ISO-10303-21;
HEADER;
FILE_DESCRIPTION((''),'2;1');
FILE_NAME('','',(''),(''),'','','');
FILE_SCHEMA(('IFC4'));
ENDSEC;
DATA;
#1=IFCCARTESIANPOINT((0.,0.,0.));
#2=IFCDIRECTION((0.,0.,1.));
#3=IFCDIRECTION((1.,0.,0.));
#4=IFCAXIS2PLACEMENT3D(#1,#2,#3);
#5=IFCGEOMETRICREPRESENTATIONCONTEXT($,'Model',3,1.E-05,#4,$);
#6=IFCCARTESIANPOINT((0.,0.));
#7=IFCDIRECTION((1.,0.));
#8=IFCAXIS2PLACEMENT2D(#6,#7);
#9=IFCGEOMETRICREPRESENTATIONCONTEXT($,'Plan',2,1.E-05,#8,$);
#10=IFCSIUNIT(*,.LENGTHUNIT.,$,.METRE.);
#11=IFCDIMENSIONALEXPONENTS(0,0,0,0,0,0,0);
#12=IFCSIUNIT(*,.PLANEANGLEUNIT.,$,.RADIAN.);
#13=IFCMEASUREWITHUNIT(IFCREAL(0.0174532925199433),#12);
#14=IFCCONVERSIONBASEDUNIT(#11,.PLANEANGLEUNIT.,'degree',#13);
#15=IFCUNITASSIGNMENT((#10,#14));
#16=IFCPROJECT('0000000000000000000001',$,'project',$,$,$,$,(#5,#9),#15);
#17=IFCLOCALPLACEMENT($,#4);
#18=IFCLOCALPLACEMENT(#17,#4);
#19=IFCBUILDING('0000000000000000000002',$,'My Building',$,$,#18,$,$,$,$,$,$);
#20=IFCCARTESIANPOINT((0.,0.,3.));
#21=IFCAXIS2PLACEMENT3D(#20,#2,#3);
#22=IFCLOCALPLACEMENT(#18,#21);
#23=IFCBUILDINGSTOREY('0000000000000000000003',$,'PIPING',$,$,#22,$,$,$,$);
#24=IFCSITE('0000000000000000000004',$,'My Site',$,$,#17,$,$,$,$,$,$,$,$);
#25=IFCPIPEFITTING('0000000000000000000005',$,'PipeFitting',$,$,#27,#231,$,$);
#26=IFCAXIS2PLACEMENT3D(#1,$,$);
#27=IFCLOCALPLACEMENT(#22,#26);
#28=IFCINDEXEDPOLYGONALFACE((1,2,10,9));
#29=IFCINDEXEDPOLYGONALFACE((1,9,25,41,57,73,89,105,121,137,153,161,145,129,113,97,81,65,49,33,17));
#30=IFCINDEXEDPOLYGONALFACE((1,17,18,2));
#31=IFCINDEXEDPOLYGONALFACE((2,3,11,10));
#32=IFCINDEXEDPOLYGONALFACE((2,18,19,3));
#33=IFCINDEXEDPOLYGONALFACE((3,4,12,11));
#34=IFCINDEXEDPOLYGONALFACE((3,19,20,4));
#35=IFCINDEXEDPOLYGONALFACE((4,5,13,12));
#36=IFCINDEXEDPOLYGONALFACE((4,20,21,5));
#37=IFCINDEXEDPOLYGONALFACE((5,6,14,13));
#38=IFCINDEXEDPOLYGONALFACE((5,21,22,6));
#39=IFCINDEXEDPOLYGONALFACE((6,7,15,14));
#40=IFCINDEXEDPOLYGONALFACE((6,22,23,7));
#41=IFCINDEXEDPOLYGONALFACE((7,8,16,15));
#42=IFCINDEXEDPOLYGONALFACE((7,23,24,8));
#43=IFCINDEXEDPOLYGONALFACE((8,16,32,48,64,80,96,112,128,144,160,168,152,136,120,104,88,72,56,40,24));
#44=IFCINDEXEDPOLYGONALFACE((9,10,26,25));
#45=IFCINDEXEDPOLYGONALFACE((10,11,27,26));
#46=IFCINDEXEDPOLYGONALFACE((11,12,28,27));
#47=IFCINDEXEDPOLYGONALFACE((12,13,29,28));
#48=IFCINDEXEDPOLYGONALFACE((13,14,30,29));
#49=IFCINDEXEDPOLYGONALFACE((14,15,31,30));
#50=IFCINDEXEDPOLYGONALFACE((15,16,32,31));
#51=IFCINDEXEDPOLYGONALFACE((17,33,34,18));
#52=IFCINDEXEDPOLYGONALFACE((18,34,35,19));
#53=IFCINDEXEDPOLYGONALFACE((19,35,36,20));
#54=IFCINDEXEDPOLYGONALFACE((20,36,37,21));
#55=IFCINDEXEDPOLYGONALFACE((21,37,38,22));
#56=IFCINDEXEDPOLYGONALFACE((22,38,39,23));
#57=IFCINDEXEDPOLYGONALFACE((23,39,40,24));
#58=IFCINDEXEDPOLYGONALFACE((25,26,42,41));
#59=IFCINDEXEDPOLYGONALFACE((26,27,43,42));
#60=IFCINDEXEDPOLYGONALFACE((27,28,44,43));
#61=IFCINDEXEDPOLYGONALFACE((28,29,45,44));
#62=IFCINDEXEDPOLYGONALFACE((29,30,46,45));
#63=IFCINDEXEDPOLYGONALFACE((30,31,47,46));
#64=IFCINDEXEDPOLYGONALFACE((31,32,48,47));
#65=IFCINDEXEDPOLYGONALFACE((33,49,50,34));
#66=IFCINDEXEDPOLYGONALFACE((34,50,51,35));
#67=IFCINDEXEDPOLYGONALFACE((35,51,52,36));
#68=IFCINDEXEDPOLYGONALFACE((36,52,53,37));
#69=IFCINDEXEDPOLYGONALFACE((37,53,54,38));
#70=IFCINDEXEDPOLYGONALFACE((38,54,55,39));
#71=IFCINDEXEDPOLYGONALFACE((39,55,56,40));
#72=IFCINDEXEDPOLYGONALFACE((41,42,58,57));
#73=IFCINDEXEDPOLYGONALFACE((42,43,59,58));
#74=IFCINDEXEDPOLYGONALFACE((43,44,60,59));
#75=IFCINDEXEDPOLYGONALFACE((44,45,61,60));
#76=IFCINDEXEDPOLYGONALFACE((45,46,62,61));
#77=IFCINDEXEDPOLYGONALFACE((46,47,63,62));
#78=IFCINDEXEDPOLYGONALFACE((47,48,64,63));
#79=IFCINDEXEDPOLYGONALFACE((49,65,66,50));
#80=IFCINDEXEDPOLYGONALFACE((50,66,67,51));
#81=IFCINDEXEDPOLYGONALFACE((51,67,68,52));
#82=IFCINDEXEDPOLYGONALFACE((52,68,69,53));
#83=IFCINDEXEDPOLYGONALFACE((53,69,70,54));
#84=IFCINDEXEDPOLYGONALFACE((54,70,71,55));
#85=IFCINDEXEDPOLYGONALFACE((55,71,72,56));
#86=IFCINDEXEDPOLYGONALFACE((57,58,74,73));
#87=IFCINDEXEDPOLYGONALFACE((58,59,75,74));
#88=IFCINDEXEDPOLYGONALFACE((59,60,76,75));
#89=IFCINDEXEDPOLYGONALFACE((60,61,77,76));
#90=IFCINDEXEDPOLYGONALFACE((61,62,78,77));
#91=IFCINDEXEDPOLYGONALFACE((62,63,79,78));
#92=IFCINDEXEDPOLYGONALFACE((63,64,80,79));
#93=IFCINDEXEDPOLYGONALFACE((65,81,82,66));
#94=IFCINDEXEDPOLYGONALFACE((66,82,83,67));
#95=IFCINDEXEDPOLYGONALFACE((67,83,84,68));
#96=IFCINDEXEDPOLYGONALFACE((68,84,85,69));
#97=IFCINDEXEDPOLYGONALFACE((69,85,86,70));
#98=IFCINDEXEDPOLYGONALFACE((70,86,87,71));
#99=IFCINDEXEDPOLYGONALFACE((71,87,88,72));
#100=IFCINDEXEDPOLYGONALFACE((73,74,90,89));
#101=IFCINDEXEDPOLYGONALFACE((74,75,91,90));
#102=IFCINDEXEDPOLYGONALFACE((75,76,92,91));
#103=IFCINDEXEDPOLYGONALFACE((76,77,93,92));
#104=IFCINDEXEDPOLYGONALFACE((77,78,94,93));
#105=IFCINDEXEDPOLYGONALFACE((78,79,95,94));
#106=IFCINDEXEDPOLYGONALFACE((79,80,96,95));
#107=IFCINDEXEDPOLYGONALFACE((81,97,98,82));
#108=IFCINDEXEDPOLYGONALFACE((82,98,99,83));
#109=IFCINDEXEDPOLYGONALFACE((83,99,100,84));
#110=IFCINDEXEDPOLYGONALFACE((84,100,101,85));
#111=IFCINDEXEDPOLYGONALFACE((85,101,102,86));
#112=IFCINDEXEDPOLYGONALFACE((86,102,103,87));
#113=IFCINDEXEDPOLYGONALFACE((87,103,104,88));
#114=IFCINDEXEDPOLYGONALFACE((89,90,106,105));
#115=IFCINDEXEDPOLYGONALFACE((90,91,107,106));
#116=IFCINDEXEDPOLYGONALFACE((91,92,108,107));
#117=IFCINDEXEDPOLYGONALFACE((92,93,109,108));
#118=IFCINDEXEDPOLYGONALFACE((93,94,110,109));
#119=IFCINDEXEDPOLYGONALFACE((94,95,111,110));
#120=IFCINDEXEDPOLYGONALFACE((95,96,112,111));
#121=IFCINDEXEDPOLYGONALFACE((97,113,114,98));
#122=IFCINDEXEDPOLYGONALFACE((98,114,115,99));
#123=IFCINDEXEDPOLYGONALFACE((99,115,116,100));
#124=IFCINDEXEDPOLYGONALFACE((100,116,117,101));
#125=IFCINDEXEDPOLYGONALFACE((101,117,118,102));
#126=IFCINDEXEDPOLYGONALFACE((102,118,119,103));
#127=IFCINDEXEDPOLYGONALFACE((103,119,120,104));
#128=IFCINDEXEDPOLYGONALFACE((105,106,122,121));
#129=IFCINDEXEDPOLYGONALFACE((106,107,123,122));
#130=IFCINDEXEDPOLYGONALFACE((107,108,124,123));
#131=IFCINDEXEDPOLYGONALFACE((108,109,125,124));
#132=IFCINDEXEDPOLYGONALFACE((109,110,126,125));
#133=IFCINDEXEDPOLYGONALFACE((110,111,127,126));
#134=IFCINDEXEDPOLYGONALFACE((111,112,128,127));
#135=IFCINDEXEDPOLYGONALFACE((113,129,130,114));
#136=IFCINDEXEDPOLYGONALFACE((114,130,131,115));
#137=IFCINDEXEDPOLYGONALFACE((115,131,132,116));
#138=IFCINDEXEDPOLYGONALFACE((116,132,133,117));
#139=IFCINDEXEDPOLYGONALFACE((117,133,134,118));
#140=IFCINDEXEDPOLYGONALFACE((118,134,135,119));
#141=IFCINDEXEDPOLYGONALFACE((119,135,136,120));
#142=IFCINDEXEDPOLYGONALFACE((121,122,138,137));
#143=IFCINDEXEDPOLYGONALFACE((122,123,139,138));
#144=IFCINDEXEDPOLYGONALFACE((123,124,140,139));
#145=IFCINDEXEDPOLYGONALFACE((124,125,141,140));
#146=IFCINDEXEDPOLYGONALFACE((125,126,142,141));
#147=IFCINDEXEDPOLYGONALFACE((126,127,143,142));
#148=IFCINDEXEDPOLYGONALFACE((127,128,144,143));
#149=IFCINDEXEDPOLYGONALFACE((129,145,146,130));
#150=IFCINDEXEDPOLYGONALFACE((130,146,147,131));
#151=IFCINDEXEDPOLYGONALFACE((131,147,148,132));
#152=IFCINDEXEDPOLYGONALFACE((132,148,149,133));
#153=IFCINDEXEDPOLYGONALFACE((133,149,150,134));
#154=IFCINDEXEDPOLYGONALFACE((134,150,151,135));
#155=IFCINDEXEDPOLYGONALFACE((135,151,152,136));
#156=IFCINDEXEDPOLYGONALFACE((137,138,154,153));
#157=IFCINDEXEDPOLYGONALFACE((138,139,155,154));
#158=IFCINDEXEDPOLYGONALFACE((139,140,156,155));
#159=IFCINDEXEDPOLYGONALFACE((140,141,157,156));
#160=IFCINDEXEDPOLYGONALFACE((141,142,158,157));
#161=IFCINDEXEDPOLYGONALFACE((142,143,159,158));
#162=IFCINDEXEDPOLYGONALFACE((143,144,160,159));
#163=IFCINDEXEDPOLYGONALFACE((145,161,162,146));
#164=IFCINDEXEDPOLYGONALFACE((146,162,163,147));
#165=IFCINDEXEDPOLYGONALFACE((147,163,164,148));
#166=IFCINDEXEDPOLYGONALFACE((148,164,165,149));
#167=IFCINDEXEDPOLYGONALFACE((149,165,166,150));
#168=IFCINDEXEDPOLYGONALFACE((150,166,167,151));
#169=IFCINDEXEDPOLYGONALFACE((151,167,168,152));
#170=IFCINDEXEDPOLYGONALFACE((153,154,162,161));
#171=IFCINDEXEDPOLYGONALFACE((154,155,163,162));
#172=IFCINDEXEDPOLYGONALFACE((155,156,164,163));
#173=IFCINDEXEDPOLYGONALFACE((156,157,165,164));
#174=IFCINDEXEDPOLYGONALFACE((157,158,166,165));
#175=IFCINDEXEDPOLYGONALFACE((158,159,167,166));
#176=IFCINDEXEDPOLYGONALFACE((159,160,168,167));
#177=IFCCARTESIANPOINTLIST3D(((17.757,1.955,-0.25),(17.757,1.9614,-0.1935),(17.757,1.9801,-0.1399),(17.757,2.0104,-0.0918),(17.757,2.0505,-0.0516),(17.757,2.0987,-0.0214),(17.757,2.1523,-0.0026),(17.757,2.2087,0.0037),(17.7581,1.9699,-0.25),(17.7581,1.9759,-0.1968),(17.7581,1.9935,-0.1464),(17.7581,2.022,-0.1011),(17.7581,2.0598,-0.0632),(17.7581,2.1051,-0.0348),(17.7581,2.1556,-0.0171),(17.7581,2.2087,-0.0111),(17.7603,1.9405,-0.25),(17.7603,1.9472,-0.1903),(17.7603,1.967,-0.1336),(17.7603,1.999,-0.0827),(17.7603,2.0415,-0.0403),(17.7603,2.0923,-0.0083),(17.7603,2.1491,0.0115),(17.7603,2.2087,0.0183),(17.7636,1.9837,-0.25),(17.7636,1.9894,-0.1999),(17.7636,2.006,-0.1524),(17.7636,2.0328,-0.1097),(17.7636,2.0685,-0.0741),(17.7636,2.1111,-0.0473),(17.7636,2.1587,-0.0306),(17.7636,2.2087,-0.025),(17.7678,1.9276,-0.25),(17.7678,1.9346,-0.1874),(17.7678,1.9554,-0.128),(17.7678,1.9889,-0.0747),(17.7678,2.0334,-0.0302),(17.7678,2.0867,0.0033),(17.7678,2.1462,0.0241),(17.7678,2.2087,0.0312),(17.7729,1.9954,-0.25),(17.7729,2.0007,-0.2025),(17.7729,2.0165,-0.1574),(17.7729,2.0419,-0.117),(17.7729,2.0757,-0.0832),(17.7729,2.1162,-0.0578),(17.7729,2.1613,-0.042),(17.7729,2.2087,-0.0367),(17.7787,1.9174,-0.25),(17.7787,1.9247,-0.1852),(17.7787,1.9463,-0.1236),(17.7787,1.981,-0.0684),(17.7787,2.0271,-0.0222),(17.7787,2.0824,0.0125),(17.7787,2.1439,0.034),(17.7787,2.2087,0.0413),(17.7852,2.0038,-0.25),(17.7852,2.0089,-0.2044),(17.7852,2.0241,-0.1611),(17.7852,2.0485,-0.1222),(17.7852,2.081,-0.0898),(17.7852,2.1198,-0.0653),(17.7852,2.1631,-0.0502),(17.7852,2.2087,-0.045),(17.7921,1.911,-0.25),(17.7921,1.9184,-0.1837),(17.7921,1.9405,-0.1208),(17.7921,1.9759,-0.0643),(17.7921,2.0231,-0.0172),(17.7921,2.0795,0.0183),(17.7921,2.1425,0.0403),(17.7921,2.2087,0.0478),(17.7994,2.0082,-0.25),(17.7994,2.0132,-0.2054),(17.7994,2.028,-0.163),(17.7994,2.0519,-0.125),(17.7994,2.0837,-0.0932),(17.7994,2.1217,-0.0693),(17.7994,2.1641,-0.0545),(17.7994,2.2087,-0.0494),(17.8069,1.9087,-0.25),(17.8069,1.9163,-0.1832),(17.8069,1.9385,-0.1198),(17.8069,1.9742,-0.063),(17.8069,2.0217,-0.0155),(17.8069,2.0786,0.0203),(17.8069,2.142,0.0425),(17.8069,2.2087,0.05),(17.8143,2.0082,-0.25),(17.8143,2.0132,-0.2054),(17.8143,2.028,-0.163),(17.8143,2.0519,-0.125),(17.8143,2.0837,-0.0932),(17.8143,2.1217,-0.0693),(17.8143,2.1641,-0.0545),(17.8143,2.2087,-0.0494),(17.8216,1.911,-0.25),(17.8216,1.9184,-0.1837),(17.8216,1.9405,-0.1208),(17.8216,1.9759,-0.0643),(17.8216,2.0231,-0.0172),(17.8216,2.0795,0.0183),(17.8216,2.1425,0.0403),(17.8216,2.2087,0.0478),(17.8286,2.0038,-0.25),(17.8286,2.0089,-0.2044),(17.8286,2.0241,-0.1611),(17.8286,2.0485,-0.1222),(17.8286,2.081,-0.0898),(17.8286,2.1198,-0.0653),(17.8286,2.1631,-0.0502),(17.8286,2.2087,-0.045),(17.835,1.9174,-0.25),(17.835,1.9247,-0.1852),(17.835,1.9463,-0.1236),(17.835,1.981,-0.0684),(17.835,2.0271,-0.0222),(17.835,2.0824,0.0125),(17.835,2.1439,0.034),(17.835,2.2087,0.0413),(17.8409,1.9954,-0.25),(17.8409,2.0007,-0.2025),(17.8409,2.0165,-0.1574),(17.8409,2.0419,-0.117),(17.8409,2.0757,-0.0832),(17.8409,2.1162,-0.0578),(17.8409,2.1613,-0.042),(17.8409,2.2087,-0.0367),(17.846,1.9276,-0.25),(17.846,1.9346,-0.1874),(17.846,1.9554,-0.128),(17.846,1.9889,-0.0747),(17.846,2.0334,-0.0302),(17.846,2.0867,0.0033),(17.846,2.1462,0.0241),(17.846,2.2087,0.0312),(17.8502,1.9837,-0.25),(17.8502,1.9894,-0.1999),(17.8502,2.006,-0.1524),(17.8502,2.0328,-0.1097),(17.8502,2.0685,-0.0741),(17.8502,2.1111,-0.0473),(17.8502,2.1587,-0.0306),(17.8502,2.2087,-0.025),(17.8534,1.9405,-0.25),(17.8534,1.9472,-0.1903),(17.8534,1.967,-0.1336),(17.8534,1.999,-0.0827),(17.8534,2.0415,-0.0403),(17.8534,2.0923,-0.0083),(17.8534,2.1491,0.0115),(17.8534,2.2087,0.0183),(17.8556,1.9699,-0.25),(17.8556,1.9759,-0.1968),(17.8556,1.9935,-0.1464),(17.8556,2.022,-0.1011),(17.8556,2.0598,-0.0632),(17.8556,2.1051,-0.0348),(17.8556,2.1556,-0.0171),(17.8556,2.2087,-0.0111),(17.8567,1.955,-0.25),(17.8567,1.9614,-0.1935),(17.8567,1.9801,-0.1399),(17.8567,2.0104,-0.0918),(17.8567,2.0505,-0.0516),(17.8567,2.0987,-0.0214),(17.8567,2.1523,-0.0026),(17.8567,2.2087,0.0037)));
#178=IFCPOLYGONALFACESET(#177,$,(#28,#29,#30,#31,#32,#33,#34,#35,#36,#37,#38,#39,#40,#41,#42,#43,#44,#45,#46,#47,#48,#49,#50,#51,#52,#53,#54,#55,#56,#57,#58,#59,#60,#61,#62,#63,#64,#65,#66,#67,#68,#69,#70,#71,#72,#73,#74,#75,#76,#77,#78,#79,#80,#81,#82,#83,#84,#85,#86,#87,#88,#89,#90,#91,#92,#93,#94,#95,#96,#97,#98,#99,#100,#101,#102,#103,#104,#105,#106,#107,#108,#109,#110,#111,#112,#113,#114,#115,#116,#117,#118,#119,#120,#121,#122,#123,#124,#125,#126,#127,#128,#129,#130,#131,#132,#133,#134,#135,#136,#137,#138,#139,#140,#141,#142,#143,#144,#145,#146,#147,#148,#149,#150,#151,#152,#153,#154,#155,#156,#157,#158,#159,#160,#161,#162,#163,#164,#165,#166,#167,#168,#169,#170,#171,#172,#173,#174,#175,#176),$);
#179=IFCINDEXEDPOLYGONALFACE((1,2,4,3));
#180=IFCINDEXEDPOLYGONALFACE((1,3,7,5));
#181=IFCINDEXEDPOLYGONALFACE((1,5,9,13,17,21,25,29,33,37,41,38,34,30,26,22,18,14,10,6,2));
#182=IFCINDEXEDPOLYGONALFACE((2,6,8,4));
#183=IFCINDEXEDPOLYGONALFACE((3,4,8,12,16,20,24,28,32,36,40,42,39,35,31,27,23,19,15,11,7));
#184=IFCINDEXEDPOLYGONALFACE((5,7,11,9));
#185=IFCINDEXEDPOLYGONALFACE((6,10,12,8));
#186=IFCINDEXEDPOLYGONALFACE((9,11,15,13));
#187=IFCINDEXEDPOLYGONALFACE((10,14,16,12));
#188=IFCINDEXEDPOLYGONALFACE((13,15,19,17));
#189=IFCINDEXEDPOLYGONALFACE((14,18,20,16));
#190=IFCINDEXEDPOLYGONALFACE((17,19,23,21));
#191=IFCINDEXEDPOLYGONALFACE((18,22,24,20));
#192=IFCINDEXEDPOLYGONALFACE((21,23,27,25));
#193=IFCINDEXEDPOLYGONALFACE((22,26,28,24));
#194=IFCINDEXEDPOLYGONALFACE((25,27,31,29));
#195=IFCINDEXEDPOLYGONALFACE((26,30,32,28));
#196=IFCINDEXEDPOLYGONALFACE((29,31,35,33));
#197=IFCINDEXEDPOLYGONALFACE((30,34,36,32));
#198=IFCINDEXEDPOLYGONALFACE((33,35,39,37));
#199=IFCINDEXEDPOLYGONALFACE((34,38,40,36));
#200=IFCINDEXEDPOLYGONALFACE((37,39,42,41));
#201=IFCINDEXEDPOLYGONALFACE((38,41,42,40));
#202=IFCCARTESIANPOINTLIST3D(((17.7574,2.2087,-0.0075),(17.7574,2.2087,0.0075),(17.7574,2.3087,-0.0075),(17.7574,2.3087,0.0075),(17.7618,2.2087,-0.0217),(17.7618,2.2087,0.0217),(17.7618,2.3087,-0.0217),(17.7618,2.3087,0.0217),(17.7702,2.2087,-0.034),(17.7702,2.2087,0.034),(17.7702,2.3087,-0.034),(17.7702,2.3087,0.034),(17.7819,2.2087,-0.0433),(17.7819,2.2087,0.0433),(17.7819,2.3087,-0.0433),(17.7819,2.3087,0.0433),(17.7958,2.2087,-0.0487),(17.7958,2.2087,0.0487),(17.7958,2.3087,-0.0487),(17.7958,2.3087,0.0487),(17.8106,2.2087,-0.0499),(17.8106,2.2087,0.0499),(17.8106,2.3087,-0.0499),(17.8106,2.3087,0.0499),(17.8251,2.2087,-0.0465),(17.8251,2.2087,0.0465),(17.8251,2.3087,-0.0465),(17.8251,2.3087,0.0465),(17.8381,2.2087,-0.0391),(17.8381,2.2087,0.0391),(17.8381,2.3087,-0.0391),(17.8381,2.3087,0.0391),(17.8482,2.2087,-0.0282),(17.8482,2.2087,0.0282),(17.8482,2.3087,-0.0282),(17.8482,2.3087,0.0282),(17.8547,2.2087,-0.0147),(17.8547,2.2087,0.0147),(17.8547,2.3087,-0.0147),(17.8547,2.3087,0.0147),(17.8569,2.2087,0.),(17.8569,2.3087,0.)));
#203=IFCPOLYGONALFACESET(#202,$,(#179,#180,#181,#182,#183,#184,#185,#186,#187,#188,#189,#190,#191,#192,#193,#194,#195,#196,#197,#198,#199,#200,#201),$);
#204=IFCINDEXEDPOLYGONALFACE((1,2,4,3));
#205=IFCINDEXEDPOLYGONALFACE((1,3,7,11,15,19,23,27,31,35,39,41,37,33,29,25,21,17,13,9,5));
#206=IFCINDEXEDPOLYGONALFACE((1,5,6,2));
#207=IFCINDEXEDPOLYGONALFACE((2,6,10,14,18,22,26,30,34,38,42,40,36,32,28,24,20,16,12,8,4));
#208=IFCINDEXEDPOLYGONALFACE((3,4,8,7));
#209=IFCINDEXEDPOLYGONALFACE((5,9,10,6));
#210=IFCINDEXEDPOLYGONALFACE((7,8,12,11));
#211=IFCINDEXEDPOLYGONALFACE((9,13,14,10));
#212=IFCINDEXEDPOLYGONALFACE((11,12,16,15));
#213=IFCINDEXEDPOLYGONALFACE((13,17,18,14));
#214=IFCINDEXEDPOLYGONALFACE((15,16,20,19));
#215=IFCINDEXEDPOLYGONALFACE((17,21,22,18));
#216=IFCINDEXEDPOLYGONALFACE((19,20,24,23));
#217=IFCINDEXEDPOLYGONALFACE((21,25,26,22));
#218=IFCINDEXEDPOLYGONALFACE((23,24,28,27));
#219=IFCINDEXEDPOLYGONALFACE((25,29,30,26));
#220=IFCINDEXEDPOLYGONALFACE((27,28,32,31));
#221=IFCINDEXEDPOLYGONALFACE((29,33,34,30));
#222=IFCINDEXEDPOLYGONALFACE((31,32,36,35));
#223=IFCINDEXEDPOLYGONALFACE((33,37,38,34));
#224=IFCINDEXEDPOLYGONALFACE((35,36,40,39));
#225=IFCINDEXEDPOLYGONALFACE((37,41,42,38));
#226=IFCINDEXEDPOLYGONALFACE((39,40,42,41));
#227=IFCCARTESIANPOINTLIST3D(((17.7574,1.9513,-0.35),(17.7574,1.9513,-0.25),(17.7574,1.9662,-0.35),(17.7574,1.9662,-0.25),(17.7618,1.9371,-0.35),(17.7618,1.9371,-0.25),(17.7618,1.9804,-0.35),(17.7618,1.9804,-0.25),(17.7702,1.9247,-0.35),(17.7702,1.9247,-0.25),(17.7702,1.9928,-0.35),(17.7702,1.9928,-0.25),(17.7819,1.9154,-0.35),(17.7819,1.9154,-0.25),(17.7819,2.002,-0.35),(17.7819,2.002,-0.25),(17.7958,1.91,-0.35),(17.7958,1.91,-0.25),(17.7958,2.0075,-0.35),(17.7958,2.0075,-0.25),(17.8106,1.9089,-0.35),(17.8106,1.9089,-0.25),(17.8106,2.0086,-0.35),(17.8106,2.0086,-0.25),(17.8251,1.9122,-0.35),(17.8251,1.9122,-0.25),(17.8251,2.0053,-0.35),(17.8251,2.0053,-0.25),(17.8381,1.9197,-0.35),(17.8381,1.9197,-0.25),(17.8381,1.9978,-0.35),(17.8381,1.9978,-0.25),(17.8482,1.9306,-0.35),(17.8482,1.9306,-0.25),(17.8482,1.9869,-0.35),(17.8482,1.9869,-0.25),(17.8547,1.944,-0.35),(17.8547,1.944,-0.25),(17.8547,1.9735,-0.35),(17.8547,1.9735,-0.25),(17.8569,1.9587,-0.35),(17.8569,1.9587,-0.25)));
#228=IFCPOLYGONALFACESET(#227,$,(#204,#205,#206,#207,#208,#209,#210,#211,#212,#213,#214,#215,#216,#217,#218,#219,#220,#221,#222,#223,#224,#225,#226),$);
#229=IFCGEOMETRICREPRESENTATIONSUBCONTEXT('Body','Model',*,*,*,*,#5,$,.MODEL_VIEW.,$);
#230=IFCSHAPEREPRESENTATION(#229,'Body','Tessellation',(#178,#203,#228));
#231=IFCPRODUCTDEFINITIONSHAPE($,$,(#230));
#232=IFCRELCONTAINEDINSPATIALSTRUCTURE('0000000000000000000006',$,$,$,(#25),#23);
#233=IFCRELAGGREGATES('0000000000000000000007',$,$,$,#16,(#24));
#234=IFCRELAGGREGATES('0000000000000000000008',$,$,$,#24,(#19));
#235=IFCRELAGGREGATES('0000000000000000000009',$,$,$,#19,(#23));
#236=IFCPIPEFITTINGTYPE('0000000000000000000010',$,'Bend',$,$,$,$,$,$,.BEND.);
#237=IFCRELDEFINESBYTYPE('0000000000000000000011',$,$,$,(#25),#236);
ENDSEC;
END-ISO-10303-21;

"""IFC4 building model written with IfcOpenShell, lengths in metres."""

from ifc_helpers import new_model, entity, si_unit, converted_unit, frame, origin_with_axes, origin_2d_with_axis, place, context, subcontext, project, spatial, circle, extrude, source, transform, mapped, type_object, type_shapes, element, save


model = new_model("IFC4")

# Units and contexts
model_context = context("Model", 3, precision=1e-05, world=origin_with_axes())
plan_context = context("Plan", 2, precision=1e-05, world=origin_2d_with_axis())
body_context = subcontext(model_context, "Body", "Model", "MODEL_VIEW")
ifc_project = project(units=[si_unit("LENGTHUNIT", "METRE"), converted_unit("PLANEANGLEUNIT", "degree", entity("IfcReal", 0.0174532925199433), si_unit("PLANEANGLEUNIT", "RADIAN"), dimensions=[0, 0, 0, 0, 0, 0, 0])], contexts=[model_context, plan_context])

# Site, building, storey
site_placement = place(None, origin_with_axes())
site = spatial("IfcSite", under=ifc_project, at=site_placement, Name="My Site")
building_placement = place(site_placement, origin_with_axes())
building = spatial("IfcBuilding", under=site, at=building_placement, Name="My Building")
storey_placement = place(building_placement, frame((0.0, 0.0, 3.0), z_axis=(0.0, 0.0, 1.0), x_axis=(1.0, 0.0, 0.0)))
storey = spatial("IfcBuildingStorey", under=building, at=storey_placement, Name="PIPING")

# Pipe fitting
pipe_fitting_type = type_object("IfcPipeFittingType", Name="Bend", PredefinedType="BEND")
shared_shape = source(origin_with_axes(), body_context, "Body", "SolidModel", [
    entity("IfcSweptDiskSolid", entity("IfcIndexedPolyCurve", entity("IfcCartesianPointList3D", [[0.0, 0.0, 0.1], [0.0, -0.0732, 0.2768], [0.0, -0.25, 0.35]]), [entity("IfcArcIndex", [1, 2, 3])]), 0.05),
    extrude(circle(Radius=0.05), origin_with_axes(), (0.0, 0.0, 1.0), 0.1),
    extrude(circle(Radius=0.05), frame((0.0, -0.25, 0.35), z_axis=(0.0, -1.0, 0.0), x_axis=(1.0, 0.0, 0.0)), (0.0, 0.0, 1.0), 0.1),
])
type_shapes(pipe_fitting_type, [shared_shape])
for number, where, z_axis, x_axis, name in (
    (1, (17.8069, 2.3087, 0.0), (0.0, -1.0, 0.0), (1.0, 0.0, 0.0), "PipeFitting"),
):
    element("IfcPipeFitting", number, at=place(storey_placement, frame(where, z_axis=z_axis, x_axis=x_axis)), inside=storey, type_object=pipe_fitting_type, Name=name, context=body_context, shape_type="MappedRepresentation", body=[
        mapped(shared_shape, transform((0.0, 0.0, 0.0), x_axis=(1.0, 0.0, 0.0), y_axis=(0.0, 1.0, 0.0), z_axis=(0.0, 0.0, 1.0), scale=1.0)),
    ])

save(model, "model.ifc")
